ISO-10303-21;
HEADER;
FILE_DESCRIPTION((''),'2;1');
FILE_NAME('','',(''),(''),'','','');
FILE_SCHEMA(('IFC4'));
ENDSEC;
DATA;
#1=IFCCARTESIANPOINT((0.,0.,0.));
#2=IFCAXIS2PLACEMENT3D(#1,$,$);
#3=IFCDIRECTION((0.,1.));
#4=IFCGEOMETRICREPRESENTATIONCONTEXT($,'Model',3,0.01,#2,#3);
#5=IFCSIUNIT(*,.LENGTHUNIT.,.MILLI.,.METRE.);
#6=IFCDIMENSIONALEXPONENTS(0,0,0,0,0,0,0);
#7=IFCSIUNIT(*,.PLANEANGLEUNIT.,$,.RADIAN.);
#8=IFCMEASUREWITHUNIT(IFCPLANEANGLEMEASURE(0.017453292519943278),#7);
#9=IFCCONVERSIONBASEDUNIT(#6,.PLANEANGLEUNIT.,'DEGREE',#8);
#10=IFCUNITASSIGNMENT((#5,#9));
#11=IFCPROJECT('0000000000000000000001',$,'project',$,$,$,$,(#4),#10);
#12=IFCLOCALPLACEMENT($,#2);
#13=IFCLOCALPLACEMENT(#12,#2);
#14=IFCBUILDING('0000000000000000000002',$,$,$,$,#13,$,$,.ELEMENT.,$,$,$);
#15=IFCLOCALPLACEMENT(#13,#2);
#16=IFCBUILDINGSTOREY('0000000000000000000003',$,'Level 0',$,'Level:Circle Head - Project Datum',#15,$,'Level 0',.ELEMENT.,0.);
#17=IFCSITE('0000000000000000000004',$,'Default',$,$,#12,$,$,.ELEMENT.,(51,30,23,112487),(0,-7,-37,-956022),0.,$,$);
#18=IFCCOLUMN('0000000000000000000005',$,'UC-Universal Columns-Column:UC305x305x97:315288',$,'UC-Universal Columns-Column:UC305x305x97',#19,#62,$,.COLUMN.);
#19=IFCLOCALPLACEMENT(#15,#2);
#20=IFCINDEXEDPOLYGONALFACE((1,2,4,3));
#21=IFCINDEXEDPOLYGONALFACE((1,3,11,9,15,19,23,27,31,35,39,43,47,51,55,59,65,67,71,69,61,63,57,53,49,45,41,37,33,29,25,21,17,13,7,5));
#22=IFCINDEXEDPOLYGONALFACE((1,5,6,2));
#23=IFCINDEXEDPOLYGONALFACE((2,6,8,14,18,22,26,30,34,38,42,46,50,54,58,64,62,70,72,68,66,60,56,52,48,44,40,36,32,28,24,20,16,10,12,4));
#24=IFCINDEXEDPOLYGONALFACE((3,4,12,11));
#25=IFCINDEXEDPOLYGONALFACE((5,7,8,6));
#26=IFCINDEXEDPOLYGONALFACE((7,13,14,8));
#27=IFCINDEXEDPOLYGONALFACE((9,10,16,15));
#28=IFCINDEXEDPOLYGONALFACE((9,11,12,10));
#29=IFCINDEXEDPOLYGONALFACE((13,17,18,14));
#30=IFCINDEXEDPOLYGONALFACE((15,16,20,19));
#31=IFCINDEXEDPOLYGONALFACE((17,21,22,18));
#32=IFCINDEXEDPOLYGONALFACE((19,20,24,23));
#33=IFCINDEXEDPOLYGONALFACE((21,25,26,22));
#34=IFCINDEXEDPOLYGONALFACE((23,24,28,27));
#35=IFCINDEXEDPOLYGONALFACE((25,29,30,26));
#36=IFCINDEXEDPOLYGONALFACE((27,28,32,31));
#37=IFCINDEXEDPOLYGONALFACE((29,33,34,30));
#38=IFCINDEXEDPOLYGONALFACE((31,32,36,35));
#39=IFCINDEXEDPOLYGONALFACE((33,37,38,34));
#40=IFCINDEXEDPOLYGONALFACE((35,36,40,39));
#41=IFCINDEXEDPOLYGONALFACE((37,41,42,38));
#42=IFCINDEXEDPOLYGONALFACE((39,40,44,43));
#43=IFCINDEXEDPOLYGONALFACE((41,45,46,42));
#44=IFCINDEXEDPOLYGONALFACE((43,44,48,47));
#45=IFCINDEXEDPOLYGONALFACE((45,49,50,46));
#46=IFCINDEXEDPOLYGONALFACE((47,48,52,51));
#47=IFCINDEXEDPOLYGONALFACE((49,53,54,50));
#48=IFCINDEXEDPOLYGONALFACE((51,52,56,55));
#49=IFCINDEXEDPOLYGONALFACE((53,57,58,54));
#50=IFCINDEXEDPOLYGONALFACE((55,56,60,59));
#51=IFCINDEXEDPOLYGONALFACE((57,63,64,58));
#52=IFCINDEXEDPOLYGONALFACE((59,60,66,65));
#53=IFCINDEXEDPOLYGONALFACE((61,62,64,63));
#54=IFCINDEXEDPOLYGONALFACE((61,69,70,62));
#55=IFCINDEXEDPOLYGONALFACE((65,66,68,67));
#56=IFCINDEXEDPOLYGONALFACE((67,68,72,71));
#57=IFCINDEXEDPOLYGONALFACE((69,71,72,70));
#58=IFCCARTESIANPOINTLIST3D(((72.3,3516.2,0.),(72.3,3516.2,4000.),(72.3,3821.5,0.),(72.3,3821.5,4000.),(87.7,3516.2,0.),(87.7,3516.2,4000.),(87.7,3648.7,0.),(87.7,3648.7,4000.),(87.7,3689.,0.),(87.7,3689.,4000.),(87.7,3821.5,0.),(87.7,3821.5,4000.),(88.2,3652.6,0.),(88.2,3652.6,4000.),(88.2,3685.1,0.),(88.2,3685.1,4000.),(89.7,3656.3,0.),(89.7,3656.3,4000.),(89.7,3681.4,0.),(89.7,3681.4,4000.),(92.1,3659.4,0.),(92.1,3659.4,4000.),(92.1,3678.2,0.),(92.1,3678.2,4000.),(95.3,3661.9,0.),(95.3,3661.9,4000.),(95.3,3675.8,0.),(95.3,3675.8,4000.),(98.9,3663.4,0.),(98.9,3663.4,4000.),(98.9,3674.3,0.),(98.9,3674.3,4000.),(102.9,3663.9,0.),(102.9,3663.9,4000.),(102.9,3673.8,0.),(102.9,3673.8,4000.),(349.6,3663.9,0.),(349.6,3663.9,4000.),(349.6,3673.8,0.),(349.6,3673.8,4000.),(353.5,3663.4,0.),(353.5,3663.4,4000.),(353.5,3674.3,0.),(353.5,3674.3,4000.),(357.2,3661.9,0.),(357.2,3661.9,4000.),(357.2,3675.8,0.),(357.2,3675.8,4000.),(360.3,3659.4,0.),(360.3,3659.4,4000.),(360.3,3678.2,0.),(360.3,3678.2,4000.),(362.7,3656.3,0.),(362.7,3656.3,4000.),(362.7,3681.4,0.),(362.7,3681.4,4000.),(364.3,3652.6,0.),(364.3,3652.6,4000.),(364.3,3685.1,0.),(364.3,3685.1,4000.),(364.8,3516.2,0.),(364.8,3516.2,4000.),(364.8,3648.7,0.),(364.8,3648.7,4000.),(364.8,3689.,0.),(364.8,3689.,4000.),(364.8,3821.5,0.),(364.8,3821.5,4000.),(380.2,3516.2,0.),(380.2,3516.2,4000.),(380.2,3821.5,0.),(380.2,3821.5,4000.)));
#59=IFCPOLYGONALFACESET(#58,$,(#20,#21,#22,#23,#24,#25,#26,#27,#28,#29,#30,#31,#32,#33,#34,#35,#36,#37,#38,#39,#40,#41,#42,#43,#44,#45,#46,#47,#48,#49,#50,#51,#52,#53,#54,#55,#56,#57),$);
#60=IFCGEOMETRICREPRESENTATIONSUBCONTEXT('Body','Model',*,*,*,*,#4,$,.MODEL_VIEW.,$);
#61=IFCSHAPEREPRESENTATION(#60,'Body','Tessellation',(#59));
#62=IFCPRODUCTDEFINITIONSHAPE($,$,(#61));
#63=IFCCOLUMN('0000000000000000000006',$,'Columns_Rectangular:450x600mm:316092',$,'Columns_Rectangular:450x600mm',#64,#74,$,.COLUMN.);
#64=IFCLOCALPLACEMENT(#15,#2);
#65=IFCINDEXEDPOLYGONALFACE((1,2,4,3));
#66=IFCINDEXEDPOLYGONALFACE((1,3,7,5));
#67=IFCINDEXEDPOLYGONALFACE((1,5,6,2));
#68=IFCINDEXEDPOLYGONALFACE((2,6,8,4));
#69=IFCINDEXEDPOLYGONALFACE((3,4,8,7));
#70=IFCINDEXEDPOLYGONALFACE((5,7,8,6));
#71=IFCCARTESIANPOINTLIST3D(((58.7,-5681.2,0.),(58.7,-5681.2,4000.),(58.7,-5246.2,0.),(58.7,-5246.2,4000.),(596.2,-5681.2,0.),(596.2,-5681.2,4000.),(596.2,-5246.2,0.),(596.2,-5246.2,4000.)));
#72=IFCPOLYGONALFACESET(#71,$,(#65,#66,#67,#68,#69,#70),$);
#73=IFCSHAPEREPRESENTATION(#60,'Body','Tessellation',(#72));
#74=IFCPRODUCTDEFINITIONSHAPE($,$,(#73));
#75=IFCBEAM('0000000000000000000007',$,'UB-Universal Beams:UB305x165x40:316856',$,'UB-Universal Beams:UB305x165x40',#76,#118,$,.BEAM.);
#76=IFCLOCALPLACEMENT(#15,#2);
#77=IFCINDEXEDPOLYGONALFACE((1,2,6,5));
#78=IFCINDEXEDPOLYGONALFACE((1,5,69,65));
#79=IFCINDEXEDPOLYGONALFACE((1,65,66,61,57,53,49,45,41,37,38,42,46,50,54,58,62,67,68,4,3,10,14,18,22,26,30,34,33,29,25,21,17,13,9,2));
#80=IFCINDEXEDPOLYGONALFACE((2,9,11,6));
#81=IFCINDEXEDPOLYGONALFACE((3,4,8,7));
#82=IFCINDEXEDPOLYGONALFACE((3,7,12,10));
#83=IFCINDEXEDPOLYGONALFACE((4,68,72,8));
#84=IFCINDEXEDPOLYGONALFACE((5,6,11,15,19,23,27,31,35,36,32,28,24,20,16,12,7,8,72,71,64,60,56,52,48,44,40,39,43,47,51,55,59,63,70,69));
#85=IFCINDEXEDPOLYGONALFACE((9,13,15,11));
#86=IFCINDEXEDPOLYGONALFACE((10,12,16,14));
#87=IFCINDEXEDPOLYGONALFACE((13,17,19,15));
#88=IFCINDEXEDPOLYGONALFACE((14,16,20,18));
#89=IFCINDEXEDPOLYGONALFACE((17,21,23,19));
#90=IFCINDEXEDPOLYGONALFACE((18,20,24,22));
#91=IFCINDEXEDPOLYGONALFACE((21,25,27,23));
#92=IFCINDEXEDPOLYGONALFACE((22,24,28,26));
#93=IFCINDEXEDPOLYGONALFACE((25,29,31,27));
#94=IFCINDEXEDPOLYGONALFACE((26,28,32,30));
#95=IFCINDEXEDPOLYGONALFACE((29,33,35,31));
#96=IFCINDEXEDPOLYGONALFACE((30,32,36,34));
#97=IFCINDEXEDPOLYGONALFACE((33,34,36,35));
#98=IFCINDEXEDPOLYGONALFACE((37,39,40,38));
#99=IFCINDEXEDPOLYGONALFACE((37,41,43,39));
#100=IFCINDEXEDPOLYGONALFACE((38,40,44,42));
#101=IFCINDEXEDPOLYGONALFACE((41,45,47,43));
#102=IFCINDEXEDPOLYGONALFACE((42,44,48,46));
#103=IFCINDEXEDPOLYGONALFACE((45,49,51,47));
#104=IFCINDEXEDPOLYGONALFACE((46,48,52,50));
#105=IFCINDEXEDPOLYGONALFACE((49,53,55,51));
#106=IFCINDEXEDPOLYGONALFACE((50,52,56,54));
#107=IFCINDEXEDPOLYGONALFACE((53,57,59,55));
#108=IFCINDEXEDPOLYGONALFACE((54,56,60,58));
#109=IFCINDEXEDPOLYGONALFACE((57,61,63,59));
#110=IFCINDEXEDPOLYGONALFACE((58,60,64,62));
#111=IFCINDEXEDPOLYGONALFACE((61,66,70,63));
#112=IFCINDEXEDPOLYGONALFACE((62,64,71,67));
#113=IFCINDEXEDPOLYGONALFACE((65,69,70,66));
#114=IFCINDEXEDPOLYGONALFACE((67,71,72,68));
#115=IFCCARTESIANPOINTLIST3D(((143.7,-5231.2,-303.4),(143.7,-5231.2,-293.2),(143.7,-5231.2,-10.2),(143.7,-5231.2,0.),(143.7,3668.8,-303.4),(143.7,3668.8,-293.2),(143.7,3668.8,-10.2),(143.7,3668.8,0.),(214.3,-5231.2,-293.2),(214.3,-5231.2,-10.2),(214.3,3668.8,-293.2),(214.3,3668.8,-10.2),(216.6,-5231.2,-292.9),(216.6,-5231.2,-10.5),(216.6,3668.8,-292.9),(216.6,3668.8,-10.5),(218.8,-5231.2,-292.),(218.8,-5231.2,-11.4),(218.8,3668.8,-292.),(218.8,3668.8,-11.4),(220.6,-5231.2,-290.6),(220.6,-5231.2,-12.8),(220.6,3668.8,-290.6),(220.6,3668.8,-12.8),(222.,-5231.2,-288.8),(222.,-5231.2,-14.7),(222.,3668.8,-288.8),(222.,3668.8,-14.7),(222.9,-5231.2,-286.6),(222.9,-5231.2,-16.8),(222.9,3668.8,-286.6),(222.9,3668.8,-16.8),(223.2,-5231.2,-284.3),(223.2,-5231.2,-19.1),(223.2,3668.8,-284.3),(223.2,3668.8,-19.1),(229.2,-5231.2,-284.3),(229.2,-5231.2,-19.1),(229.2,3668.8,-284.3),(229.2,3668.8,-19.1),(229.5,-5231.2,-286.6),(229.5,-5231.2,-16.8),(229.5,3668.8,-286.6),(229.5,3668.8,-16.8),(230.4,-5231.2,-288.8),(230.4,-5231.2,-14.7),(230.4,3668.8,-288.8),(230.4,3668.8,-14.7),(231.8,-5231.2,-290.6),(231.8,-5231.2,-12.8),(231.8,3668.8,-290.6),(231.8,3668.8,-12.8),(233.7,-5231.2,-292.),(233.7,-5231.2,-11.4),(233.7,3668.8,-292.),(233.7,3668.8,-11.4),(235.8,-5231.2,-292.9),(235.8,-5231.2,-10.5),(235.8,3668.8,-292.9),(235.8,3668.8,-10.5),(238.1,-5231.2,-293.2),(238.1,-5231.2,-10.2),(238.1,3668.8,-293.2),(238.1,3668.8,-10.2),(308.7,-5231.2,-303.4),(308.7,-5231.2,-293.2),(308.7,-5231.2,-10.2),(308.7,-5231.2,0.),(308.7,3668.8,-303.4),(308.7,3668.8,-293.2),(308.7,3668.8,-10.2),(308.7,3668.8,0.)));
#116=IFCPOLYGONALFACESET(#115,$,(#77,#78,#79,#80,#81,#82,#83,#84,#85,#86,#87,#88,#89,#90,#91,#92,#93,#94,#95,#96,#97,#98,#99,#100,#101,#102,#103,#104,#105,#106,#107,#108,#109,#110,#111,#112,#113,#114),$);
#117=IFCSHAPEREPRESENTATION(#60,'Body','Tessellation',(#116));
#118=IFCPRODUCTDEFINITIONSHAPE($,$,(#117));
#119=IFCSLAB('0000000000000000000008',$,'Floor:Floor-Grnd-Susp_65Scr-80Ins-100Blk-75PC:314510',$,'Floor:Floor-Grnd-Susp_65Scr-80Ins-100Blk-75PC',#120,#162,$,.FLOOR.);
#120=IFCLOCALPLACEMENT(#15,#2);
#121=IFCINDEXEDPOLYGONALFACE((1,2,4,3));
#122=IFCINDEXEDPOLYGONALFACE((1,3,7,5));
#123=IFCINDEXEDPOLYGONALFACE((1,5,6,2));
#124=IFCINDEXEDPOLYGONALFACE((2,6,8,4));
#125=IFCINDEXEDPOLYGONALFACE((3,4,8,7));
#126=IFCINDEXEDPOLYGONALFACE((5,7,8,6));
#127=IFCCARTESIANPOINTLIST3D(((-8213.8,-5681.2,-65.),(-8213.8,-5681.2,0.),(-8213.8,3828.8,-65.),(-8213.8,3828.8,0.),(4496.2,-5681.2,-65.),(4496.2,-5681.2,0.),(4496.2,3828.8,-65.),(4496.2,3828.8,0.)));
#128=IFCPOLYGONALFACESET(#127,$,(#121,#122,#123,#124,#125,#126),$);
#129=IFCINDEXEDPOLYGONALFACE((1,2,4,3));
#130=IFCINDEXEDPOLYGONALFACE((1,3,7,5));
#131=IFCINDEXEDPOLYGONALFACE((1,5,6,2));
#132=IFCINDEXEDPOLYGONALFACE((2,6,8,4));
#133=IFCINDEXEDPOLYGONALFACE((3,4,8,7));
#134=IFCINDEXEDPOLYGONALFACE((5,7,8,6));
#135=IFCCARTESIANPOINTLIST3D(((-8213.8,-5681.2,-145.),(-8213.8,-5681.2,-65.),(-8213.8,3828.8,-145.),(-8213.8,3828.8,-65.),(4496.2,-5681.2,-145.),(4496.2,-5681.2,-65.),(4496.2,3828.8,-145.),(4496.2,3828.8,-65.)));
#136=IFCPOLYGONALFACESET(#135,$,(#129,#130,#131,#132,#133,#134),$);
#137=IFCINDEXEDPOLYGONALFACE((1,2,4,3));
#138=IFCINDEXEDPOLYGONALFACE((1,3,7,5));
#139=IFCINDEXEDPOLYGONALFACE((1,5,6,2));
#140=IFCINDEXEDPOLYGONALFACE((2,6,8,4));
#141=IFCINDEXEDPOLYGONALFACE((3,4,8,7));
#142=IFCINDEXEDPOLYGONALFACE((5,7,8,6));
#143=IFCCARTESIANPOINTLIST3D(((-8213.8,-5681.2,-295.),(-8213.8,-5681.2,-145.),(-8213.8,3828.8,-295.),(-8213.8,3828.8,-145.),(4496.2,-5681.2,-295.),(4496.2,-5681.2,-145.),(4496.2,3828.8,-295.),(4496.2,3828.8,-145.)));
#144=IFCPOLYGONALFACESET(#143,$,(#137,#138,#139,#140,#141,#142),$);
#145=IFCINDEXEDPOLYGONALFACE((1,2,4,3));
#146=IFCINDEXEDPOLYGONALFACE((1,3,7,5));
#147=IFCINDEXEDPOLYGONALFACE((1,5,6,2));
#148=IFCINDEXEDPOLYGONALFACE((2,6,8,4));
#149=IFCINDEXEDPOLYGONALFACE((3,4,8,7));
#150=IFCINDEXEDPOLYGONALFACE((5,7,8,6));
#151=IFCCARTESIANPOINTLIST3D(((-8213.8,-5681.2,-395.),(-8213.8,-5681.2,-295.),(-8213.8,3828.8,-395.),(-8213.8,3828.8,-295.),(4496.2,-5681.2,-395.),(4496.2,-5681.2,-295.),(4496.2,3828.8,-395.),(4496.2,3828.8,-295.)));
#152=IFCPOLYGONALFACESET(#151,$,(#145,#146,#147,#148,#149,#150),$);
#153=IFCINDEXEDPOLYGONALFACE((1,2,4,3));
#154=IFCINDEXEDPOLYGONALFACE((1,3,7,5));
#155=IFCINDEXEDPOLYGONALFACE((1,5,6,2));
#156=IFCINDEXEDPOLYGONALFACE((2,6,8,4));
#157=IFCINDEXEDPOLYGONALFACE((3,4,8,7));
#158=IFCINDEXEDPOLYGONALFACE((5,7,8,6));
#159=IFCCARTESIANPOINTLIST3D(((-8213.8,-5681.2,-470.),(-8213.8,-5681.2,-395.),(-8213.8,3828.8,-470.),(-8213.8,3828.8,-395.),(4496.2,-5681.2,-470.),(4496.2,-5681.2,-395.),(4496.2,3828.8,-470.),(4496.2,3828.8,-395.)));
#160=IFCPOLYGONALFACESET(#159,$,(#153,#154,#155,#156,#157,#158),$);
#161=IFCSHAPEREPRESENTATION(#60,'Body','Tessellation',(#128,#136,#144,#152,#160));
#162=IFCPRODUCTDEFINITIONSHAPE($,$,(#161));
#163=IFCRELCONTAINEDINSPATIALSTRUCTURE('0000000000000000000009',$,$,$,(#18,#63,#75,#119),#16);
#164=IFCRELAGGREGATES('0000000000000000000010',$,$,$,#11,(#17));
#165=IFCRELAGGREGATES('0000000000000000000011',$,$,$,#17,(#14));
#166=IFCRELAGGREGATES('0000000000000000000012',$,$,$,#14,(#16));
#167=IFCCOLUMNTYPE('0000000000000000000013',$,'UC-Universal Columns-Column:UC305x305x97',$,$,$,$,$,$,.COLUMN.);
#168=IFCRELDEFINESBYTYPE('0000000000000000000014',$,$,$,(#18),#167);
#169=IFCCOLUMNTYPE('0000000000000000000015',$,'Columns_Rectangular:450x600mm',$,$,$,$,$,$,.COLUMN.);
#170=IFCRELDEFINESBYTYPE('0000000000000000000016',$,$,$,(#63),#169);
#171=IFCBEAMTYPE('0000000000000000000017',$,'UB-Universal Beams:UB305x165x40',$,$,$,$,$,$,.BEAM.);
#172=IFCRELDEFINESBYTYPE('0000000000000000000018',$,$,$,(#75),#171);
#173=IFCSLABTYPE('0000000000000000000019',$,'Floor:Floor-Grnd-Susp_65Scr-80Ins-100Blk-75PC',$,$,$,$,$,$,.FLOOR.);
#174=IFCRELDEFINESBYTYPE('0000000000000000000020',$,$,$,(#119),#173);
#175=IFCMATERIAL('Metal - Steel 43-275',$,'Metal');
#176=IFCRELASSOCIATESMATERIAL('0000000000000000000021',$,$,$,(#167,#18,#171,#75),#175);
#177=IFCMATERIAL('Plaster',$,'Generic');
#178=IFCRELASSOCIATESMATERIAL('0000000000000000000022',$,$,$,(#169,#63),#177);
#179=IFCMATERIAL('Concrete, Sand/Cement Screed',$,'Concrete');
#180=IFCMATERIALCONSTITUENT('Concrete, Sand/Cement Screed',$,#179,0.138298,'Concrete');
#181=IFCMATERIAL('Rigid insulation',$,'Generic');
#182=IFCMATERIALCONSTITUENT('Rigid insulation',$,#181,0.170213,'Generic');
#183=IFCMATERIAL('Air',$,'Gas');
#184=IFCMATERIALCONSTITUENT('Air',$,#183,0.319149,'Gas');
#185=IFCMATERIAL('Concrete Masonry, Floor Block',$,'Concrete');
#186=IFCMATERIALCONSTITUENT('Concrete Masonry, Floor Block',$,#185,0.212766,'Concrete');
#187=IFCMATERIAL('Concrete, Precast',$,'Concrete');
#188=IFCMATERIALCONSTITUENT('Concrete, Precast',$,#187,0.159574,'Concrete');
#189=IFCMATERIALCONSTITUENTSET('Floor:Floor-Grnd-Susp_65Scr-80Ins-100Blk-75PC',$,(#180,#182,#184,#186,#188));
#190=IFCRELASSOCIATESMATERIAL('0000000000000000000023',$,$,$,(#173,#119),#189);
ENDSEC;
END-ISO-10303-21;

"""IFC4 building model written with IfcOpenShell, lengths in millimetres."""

from ifc_helpers import new_model, entity, si_unit, converted_unit, direction, frame, origin, place, context, subcontext, project, spatial, line, arc, indexed_curve, outline, extrude, source, transform, mapped, material, constituent, constituent_set, type_object, type_shapes, element, save


model = new_model("IFC4")

# Units and contexts
model_context = context("Model", 3, precision=0.01, world=origin(), true_north=direction((0.0, 1.0)))
body_context = subcontext(model_context, "Body", "Model", "MODEL_VIEW")
ifc_project = project(units=[si_unit("LENGTHUNIT", "METRE", prefix="MILLI"), converted_unit("PLANEANGLEUNIT", "DEGREE", entity("IfcPlaneAngleMeasure", 0.017453292519943278), si_unit("PLANEANGLEUNIT", "RADIAN"), dimensions=[0, 0, 0, 0, 0, 0, 0])], contexts=[model_context])

# Site, building, storey
site_placement = place(None, origin())
site = spatial("IfcSite", under=ifc_project, at=site_placement, Name="Default", CompositionType="ELEMENT", RefLatitude=(51, 30, 23, 112487), RefLongitude=(0, -7, -37, -956022), RefElevation=0.0)
building_placement = place(site_placement, origin())
building = spatial("IfcBuilding", under=site, at=building_placement, CompositionType="ELEMENT")
storey_placement = place(building_placement, origin())
storey = spatial("IfcBuildingStorey", under=building, at=storey_placement, Name="Level 0", ObjectType="Level:Circle Head - Project Datum", LongName="Level 0", CompositionType="ELEMENT", Elevation=0.0)

# Columns
ifc_material_1 = material(Name="Metal - Steel 43-275", Category="Metal")
column_type_1 = type_object("IfcColumnType", Name="UC-Universal Columns-Column:UC305x305x97", PredefinedType="COLUMN", material=ifc_material_1)
shared_shape_1 = source(origin(), body_context, "Body", "SweptSolid", [
    extrude(outline(indexed_curve([(-152.6, -153.9), (152.6, -153.9), (152.6, -138.5), (20.2, -138.5), (9.4, -134.1), (4.9, -123.4), (4.9, 123.3), (9.4, 134.1), (20.1, 138.5), (152.6, 138.5), (152.6, 153.9), (-152.6, 153.9), (-152.6, 138.5), (-20.2, 138.6), (-9.4, 134.1), (-5.0, 123.4), (-5.0, -123.3), (-9.4, -134.1), (-20.2, -138.5), (-152.6, -138.5)], segments=[line(1, 2, 3, 4), arc(4, 5, 6), line(6, 7), arc(7, 8, 9), line(9, 10, 11, 12, 13, 14), arc(14, 15, 16), line(16, 17), arc(17, 18, 19), line(19, 20, 1)], self_intersect=False)), frame((0.0, 0.0, 0.0), z_axis=(0.0, 0.0, 1.0), x_axis=(-1.0, 0.0, 0.0)), (0.0, 0.0, 1.0), 4000.0),
])
type_shapes(column_type_1, [shared_shape_1])
column_1_placement = place(storey_placement, frame((226.2, 3668.8, 0.0), z_axis=(0.0, 0.0, 1.0), x_axis=(0.0, -1.0, 0.0)))
element("IfcColumn", 1, at=column_1_placement, inside=storey, type_object=column_type_1, material=ifc_material_1, Name="UC-Universal Columns-Column:UC305x305x97:315288", ObjectType="UC-Universal Columns-Column:UC305x305x97", PredefinedType="COLUMN", context=body_context, shape_type="MappedRepresentation", body=[
    mapped(shared_shape_1, transform((0.0, 0.0, 0.0), scale=1.0)),
])
ifc_material_2 = material(Name="Plaster", Category="Generic")
column_type_2 = type_object("IfcColumnType", Name="Columns_Rectangular:450x600mm", PredefinedType="COLUMN", material=ifc_material_2)
shared_shape_2 = source(origin(), body_context, "Body", "SweptSolid", [
    extrude(outline(indexed_curve([(-268.7, -217.5), (268.7, -217.5), (268.7, 217.5), (-268.7, 217.5), (-268.7, -217.5)], self_intersect=False)), frame((327.5, -5463.7, 0.0), z_axis=(0.0, 0.0, 1.0), x_axis=(-1.0, 0.0, 0.0)), (0.0, 0.0, 1.0), 4000.0),
])
type_shapes(column_type_2, [shared_shape_2])
column_2_placement = place(storey_placement, origin())
element("IfcColumn", 2, at=column_2_placement, inside=storey, type_object=column_type_2, material=ifc_material_2, Name="Columns_Rectangular:450x600mm:316092", ObjectType="Columns_Rectangular:450x600mm", PredefinedType="COLUMN", context=body_context, shape_type="MappedRepresentation", body=[
    mapped(shared_shape_2, transform((0.0, 0.0, 0.0), scale=1.0)),
])

# Beam
beam_type = type_object("IfcBeamType", Name="UB-Universal Beams:UB305x165x40", PredefinedType="BEAM", material=ifc_material_1)
shared_shape_3 = source(origin(), body_context, "Body", "SweptSolid", [
    extrude(outline(indexed_curve([(-82.5, -141.5), (-82.5, -151.7), (82.5, -151.7), (82.5, -141.5), (11.9, -141.5), (5.6, -138.9), (3.0, -132.6), (3.0, 132.6), (5.6, 138.9), (11.9, 141.5), (82.5, 141.5), (82.5, 151.7), (-82.5, 151.7), (-82.5, 141.5), (-11.9, 141.5), (-5.6, 138.9), (-3.0, 132.6), (-3.0, -132.6), (-5.6, -138.9), (-11.9, -141.5)], segments=[line(1, 2, 3, 4, 5), arc(5, 6, 7), line(7, 8), arc(8, 9, 10), line(10, 11, 12, 13, 14, 15), arc(15, 16, 17), line(17, 18), arc(18, 19, 20), line(20, 1)], self_intersect=False)), frame((-4450.0, 0.0, 0.0), z_axis=(-1.0, 0.0, 0.0), x_axis=(0.0, -1.0, 0.0)), (0.0, 0.0, -1.0), 8900.0),
])
type_shapes(beam_type, [shared_shape_3])
beam_placement = place(storey_placement, frame((226.2, -781.2, -151.7), z_axis=(0.0, 0.0, 1.0), x_axis=(0.0, -1.0, 0.0)))
element("IfcBeam", 3, at=beam_placement, inside=storey, type_object=beam_type, material=ifc_material_1, Name="UB-Universal Beams:UB305x165x40:316856", ObjectType="UB-Universal Beams:UB305x165x40", PredefinedType="BEAM", context=body_context, shape_type="MappedRepresentation", body=[
    mapped(shared_shape_3, transform((0.0, 0.0, 0.0), scale=1.0)),
])

# Slab
ifc_material_3 = material(Name="Concrete, Sand/Cement Screed", Category="Concrete")
ifc_constituent_1 = constituent(ifc_material_3, Name="Concrete, Sand/Cement Screed", Category="Concrete", fraction=0.138298)
ifc_material_4 = material(Name="Rigid insulation", Category="Generic")
ifc_constituent_2 = constituent(ifc_material_4, Name="Rigid insulation", Category="Generic", fraction=0.170213)
ifc_material_5 = material(Name="Air", Category="Gas")
ifc_constituent_3 = constituent(ifc_material_5, Name="Air", Category="Gas", fraction=0.319149)
ifc_material_6 = material(Name="Concrete Masonry, Floor Block", Category="Concrete")
ifc_constituent_4 = constituent(ifc_material_6, Name="Concrete Masonry, Floor Block", Category="Concrete", fraction=0.212766)
ifc_material_7 = material(Name="Concrete, Precast", Category="Concrete")
ifc_constituent_5 = constituent(ifc_material_7, Name="Concrete, Precast", Category="Concrete", fraction=0.159574)
ifc_constituent_set_1 = constituent_set(constituents=[ifc_constituent_1, ifc_constituent_2, ifc_constituent_3, ifc_constituent_4, ifc_constituent_5], Name="Floor:Floor-Grnd-Susp_65Scr-80Ins-100Blk-75PC")
slab_type = type_object("IfcSlabType", Name="Floor:Floor-Grnd-Susp_65Scr-80Ins-100Blk-75PC", PredefinedType="FLOOR", material=ifc_constituent_set_1)
slab_placement = place(storey_placement, origin())
element("IfcSlab", 4, at=slab_placement, inside=storey, type_object=slab_type, material=ifc_constituent_set_1, Name="Floor:Floor-Grnd-Susp_65Scr-80Ins-100Blk-75PC:314510", ObjectType="Floor:Floor-Grnd-Susp_65Scr-80Ins-100Blk-75PC", PredefinedType="FLOOR", context=body_context, shape_type="SweptSolid", body=[
    extrude(outline(indexed_curve([(-6355.0, -4755.0), (6355.0, -4755.0), (6355.0, 4755.0), (-6355.0, 4755.0), (-6355.0, -4755.0)], self_intersect=False)), frame((-1858.8, -926.2, -65.0), z_axis=(0.0, 0.0, 1.0), x_axis=(-1.0, 0.0, 0.0)), (0.0, 0.0, 1.0), 65.0),
    extrude(outline(indexed_curve([(-6355.0, -4755.0), (6355.0, -4755.0), (6355.0, 4755.0), (-6355.0, 4755.0), (-6355.0, -4755.0)], self_intersect=False)), frame((-1858.8, -926.2, -145.0), z_axis=(0.0, 0.0, 1.0), x_axis=(-1.0, 0.0, 0.0)), (0.0, 0.0, 1.0), 80.0),
    extrude(outline(indexed_curve([(-6355.0, -4755.0), (6355.0, -4755.0), (6355.0, 4755.0), (-6355.0, 4755.0), (-6355.0, -4755.0)], self_intersect=False)), frame((-1858.8, -926.2, -295.0), z_axis=(0.0, 0.0, 1.0), x_axis=(-1.0, 0.0, 0.0)), (0.0, 0.0, 1.0), 150.0),
    extrude(outline(indexed_curve([(-6355.0, -4755.0), (6355.0, -4755.0), (6355.0, 4755.0), (-6355.0, 4755.0), (-6355.0, -4755.0)], self_intersect=False)), frame((-1858.8, -926.2, -395.0), z_axis=(0.0, 0.0, 1.0), x_axis=(-1.0, 0.0, 0.0)), (0.0, 0.0, 1.0), 100.0),
    extrude(outline(indexed_curve([(-6355.0, -4755.0), (6355.0, -4755.0), (6355.0, 4755.0), (-6355.0, 4755.0), (-6355.0, -4755.0)], self_intersect=False)), frame((-1858.8, -926.2, -470.0), z_axis=(0.0, 0.0, 1.0), x_axis=(-1.0, 0.0, 0.0)), (0.0, 0.0, 1.0), 75.0),
])

save(model, "model.ifc")
